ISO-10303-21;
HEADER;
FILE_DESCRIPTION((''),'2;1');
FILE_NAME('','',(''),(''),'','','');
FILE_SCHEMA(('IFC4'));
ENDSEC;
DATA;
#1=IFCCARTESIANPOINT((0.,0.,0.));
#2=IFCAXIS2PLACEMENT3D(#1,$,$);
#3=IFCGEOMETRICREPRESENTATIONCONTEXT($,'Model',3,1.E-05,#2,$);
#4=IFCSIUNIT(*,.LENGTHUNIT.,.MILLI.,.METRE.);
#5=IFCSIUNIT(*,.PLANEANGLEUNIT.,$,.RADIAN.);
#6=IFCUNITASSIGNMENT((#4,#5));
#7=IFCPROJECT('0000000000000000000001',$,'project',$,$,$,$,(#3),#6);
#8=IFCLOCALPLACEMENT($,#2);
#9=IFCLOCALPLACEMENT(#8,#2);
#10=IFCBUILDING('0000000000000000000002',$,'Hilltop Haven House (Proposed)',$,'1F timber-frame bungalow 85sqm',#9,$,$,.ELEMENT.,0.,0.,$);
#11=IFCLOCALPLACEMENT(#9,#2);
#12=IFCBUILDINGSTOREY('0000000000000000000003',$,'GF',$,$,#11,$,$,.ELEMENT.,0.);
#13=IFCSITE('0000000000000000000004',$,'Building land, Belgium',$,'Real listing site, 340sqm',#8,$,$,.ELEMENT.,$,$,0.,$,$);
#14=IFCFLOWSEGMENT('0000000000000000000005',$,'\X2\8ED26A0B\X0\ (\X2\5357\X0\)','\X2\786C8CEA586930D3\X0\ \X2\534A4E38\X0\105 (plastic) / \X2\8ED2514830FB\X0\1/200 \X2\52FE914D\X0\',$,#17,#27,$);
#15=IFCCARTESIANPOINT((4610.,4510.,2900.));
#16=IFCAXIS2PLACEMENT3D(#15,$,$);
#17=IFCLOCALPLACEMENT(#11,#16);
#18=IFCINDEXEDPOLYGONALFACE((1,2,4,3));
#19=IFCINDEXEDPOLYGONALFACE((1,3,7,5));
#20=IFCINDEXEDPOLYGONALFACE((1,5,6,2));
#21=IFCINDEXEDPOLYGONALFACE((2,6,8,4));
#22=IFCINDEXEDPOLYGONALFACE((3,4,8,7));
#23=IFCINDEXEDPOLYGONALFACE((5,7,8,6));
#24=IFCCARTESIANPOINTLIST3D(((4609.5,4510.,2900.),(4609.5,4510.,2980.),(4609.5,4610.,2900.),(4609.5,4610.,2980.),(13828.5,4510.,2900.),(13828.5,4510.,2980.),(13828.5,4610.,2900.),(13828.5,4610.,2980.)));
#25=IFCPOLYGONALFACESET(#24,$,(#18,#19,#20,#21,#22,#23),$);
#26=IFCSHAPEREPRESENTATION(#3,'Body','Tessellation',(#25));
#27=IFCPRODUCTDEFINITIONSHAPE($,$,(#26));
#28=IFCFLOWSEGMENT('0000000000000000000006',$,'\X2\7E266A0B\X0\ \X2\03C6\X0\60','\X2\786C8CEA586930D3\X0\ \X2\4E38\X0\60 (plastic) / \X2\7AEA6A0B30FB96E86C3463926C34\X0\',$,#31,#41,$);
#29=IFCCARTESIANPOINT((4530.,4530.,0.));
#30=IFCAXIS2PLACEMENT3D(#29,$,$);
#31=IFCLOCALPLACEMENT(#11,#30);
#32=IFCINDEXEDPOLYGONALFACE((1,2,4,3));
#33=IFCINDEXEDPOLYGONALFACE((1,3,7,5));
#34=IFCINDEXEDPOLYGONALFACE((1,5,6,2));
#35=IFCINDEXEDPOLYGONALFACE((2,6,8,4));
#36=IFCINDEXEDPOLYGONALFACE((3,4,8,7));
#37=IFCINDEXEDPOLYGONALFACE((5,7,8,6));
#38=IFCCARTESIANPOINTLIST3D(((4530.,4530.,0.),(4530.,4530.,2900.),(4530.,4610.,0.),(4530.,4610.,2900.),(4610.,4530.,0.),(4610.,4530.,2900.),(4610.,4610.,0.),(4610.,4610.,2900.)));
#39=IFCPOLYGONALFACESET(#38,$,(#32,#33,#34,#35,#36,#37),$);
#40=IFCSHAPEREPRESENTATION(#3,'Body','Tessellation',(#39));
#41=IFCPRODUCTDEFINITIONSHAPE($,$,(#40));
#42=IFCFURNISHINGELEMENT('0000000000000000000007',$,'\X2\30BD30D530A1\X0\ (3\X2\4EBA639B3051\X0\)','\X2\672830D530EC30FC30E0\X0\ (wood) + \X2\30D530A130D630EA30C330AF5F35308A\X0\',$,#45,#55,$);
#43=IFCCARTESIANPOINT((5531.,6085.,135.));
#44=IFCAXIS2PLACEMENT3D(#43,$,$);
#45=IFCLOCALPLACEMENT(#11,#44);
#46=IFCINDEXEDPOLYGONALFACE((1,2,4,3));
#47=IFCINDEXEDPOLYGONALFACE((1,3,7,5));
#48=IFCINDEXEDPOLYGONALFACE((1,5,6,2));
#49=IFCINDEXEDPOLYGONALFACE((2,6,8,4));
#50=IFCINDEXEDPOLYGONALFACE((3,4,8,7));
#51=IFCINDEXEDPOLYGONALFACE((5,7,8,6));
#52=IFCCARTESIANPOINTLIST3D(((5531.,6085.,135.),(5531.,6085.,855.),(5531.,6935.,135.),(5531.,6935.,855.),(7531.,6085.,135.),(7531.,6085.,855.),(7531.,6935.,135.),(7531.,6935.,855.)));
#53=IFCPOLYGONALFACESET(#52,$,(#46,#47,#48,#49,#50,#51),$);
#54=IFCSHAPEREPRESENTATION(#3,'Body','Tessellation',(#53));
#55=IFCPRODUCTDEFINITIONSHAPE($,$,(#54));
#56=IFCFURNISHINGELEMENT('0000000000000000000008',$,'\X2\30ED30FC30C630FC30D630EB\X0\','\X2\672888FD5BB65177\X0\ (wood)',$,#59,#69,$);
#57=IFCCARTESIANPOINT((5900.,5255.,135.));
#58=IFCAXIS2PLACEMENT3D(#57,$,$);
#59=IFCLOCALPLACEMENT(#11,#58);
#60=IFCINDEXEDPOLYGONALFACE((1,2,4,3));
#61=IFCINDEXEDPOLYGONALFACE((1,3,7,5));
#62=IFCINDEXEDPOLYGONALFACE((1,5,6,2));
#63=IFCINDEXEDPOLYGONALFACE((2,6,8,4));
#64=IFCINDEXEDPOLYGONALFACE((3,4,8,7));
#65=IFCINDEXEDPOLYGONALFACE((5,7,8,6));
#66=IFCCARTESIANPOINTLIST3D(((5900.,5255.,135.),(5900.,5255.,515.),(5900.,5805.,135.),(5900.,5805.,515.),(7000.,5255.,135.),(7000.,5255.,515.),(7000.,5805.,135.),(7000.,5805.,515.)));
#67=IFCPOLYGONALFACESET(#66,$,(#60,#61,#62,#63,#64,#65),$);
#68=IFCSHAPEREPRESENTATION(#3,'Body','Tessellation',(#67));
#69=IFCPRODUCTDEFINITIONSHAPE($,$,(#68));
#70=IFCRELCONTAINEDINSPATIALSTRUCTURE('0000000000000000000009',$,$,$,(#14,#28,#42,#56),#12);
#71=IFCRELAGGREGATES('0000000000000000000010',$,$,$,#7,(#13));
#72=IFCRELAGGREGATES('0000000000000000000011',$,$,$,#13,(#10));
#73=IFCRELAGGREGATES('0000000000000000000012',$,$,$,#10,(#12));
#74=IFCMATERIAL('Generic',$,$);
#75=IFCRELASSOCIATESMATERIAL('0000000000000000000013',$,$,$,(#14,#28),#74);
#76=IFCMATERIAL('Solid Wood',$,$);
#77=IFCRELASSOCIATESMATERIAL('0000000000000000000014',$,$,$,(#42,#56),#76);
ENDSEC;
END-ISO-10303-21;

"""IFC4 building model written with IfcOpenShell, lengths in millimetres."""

from ifc_helpers import new_model, si_unit, frame, frame_2d, origin, place, context, project, spatial, rectangle, extrude, material, element, save


model = new_model("IFC4")

# Units and contexts
model_context = context("Model", 3, precision=1e-05, world=origin())
ifc_project = project(units=[si_unit("LENGTHUNIT", "METRE", prefix="MILLI"), si_unit("PLANEANGLEUNIT", "RADIAN")], contexts=[model_context])

# Site, building, storey
site_placement = place(None, origin())
site = spatial("IfcSite", under=ifc_project, at=site_placement, Name="Building land, Belgium", ObjectType="Real listing site, 340sqm", CompositionType="ELEMENT", RefElevation=0.0)
building_placement = place(site_placement, origin())
building = spatial("IfcBuilding", under=site, at=building_placement, Name="Hilltop Haven House (Proposed)", ObjectType="1F timber-frame bungalow 85sqm", CompositionType="ELEMENT", ElevationOfRefHeight=0.0, ElevationOfTerrain=0.0)
storey_placement = place(building_placement, origin())
storey = spatial("IfcBuildingStorey", under=building, at=storey_placement, Name="GF", CompositionType="ELEMENT", Elevation=0.0)

# Shared definitions
ifc_material_1 = material(Name="Solid Wood")

# Shared definitions
ifc_material_2 = material(Name="Generic")

# Flow segments
flow_segment_1_placement = place(storey_placement, frame((4610.0, 4510.0, 2900.0)))
element("IfcFlowSegment", 1, at=flow_segment_1_placement, inside=storey, material=ifc_material_2, Name="軒樋 (南)", Description="硬質塩ビ 半丸105 (plastic) / 軒先・1/200 勾配", context=model_context, shape_type="SweptSolid", body=[
    extrude(rectangle(XDim=9219.0, YDim=100.0, at=frame_2d((4609.0, 50.0))), frame((4610.0, 4510.0, 2900.0)), (0.0, 0.0, 1.0), 80.0),
])
flow_segment_2_placement = place(storey_placement, frame((4530.0, 4530.0, 0.0)))
element("IfcFlowSegment", 2, at=flow_segment_2_placement, inside=storey, material=ifc_material_2, Name="縦樋 φ60", Description="硬質塩ビ 丸60 (plastic) / 竪樋・雨水排水", context=model_context, shape_type="SweptSolid", body=[
    extrude(rectangle(XDim=80.0, YDim=80.0, at=frame_2d((40.0, 40.0))), frame((4530.0, 4530.0, 0.0)), (0.0, 0.0, 1.0), 2900.0),
])

# Furnishing elements
furnishing_1_placement = place(storey_placement, frame((5531.0, 6085.0, 135.0)))
element("IfcFurnishingElement", 3, at=furnishing_1_placement, inside=storey, material=ifc_material_1, Name="ソファ (3人掛け)", Description="木フレーム (wood) + ファブリック張り", context=model_context, shape_type="SweptSolid", body=[
    extrude(rectangle(XDim=2000.0, YDim=850.0, at=frame_2d((1000.0, 425.0))), frame((5531.0, 6085.0, 135.0)), (0.0, 0.0, 1.0), 720.0),
])
furnishing_2_placement = place(storey_placement, frame((5900.0, 5255.0, 135.0)))
element("IfcFurnishingElement", 4, at=furnishing_2_placement, inside=storey, material=ifc_material_1, Name="ローテーブル", Description="木製家具 (wood)", context=model_context, shape_type="SweptSolid", body=[
    extrude(rectangle(XDim=1100.0, YDim=550.0, at=frame_2d((550.0, 275.0))), frame((5900.0, 5255.0, 135.0)), (0.0, 0.0, 1.0), 380.0),
])

save(model, "model.ifc")
